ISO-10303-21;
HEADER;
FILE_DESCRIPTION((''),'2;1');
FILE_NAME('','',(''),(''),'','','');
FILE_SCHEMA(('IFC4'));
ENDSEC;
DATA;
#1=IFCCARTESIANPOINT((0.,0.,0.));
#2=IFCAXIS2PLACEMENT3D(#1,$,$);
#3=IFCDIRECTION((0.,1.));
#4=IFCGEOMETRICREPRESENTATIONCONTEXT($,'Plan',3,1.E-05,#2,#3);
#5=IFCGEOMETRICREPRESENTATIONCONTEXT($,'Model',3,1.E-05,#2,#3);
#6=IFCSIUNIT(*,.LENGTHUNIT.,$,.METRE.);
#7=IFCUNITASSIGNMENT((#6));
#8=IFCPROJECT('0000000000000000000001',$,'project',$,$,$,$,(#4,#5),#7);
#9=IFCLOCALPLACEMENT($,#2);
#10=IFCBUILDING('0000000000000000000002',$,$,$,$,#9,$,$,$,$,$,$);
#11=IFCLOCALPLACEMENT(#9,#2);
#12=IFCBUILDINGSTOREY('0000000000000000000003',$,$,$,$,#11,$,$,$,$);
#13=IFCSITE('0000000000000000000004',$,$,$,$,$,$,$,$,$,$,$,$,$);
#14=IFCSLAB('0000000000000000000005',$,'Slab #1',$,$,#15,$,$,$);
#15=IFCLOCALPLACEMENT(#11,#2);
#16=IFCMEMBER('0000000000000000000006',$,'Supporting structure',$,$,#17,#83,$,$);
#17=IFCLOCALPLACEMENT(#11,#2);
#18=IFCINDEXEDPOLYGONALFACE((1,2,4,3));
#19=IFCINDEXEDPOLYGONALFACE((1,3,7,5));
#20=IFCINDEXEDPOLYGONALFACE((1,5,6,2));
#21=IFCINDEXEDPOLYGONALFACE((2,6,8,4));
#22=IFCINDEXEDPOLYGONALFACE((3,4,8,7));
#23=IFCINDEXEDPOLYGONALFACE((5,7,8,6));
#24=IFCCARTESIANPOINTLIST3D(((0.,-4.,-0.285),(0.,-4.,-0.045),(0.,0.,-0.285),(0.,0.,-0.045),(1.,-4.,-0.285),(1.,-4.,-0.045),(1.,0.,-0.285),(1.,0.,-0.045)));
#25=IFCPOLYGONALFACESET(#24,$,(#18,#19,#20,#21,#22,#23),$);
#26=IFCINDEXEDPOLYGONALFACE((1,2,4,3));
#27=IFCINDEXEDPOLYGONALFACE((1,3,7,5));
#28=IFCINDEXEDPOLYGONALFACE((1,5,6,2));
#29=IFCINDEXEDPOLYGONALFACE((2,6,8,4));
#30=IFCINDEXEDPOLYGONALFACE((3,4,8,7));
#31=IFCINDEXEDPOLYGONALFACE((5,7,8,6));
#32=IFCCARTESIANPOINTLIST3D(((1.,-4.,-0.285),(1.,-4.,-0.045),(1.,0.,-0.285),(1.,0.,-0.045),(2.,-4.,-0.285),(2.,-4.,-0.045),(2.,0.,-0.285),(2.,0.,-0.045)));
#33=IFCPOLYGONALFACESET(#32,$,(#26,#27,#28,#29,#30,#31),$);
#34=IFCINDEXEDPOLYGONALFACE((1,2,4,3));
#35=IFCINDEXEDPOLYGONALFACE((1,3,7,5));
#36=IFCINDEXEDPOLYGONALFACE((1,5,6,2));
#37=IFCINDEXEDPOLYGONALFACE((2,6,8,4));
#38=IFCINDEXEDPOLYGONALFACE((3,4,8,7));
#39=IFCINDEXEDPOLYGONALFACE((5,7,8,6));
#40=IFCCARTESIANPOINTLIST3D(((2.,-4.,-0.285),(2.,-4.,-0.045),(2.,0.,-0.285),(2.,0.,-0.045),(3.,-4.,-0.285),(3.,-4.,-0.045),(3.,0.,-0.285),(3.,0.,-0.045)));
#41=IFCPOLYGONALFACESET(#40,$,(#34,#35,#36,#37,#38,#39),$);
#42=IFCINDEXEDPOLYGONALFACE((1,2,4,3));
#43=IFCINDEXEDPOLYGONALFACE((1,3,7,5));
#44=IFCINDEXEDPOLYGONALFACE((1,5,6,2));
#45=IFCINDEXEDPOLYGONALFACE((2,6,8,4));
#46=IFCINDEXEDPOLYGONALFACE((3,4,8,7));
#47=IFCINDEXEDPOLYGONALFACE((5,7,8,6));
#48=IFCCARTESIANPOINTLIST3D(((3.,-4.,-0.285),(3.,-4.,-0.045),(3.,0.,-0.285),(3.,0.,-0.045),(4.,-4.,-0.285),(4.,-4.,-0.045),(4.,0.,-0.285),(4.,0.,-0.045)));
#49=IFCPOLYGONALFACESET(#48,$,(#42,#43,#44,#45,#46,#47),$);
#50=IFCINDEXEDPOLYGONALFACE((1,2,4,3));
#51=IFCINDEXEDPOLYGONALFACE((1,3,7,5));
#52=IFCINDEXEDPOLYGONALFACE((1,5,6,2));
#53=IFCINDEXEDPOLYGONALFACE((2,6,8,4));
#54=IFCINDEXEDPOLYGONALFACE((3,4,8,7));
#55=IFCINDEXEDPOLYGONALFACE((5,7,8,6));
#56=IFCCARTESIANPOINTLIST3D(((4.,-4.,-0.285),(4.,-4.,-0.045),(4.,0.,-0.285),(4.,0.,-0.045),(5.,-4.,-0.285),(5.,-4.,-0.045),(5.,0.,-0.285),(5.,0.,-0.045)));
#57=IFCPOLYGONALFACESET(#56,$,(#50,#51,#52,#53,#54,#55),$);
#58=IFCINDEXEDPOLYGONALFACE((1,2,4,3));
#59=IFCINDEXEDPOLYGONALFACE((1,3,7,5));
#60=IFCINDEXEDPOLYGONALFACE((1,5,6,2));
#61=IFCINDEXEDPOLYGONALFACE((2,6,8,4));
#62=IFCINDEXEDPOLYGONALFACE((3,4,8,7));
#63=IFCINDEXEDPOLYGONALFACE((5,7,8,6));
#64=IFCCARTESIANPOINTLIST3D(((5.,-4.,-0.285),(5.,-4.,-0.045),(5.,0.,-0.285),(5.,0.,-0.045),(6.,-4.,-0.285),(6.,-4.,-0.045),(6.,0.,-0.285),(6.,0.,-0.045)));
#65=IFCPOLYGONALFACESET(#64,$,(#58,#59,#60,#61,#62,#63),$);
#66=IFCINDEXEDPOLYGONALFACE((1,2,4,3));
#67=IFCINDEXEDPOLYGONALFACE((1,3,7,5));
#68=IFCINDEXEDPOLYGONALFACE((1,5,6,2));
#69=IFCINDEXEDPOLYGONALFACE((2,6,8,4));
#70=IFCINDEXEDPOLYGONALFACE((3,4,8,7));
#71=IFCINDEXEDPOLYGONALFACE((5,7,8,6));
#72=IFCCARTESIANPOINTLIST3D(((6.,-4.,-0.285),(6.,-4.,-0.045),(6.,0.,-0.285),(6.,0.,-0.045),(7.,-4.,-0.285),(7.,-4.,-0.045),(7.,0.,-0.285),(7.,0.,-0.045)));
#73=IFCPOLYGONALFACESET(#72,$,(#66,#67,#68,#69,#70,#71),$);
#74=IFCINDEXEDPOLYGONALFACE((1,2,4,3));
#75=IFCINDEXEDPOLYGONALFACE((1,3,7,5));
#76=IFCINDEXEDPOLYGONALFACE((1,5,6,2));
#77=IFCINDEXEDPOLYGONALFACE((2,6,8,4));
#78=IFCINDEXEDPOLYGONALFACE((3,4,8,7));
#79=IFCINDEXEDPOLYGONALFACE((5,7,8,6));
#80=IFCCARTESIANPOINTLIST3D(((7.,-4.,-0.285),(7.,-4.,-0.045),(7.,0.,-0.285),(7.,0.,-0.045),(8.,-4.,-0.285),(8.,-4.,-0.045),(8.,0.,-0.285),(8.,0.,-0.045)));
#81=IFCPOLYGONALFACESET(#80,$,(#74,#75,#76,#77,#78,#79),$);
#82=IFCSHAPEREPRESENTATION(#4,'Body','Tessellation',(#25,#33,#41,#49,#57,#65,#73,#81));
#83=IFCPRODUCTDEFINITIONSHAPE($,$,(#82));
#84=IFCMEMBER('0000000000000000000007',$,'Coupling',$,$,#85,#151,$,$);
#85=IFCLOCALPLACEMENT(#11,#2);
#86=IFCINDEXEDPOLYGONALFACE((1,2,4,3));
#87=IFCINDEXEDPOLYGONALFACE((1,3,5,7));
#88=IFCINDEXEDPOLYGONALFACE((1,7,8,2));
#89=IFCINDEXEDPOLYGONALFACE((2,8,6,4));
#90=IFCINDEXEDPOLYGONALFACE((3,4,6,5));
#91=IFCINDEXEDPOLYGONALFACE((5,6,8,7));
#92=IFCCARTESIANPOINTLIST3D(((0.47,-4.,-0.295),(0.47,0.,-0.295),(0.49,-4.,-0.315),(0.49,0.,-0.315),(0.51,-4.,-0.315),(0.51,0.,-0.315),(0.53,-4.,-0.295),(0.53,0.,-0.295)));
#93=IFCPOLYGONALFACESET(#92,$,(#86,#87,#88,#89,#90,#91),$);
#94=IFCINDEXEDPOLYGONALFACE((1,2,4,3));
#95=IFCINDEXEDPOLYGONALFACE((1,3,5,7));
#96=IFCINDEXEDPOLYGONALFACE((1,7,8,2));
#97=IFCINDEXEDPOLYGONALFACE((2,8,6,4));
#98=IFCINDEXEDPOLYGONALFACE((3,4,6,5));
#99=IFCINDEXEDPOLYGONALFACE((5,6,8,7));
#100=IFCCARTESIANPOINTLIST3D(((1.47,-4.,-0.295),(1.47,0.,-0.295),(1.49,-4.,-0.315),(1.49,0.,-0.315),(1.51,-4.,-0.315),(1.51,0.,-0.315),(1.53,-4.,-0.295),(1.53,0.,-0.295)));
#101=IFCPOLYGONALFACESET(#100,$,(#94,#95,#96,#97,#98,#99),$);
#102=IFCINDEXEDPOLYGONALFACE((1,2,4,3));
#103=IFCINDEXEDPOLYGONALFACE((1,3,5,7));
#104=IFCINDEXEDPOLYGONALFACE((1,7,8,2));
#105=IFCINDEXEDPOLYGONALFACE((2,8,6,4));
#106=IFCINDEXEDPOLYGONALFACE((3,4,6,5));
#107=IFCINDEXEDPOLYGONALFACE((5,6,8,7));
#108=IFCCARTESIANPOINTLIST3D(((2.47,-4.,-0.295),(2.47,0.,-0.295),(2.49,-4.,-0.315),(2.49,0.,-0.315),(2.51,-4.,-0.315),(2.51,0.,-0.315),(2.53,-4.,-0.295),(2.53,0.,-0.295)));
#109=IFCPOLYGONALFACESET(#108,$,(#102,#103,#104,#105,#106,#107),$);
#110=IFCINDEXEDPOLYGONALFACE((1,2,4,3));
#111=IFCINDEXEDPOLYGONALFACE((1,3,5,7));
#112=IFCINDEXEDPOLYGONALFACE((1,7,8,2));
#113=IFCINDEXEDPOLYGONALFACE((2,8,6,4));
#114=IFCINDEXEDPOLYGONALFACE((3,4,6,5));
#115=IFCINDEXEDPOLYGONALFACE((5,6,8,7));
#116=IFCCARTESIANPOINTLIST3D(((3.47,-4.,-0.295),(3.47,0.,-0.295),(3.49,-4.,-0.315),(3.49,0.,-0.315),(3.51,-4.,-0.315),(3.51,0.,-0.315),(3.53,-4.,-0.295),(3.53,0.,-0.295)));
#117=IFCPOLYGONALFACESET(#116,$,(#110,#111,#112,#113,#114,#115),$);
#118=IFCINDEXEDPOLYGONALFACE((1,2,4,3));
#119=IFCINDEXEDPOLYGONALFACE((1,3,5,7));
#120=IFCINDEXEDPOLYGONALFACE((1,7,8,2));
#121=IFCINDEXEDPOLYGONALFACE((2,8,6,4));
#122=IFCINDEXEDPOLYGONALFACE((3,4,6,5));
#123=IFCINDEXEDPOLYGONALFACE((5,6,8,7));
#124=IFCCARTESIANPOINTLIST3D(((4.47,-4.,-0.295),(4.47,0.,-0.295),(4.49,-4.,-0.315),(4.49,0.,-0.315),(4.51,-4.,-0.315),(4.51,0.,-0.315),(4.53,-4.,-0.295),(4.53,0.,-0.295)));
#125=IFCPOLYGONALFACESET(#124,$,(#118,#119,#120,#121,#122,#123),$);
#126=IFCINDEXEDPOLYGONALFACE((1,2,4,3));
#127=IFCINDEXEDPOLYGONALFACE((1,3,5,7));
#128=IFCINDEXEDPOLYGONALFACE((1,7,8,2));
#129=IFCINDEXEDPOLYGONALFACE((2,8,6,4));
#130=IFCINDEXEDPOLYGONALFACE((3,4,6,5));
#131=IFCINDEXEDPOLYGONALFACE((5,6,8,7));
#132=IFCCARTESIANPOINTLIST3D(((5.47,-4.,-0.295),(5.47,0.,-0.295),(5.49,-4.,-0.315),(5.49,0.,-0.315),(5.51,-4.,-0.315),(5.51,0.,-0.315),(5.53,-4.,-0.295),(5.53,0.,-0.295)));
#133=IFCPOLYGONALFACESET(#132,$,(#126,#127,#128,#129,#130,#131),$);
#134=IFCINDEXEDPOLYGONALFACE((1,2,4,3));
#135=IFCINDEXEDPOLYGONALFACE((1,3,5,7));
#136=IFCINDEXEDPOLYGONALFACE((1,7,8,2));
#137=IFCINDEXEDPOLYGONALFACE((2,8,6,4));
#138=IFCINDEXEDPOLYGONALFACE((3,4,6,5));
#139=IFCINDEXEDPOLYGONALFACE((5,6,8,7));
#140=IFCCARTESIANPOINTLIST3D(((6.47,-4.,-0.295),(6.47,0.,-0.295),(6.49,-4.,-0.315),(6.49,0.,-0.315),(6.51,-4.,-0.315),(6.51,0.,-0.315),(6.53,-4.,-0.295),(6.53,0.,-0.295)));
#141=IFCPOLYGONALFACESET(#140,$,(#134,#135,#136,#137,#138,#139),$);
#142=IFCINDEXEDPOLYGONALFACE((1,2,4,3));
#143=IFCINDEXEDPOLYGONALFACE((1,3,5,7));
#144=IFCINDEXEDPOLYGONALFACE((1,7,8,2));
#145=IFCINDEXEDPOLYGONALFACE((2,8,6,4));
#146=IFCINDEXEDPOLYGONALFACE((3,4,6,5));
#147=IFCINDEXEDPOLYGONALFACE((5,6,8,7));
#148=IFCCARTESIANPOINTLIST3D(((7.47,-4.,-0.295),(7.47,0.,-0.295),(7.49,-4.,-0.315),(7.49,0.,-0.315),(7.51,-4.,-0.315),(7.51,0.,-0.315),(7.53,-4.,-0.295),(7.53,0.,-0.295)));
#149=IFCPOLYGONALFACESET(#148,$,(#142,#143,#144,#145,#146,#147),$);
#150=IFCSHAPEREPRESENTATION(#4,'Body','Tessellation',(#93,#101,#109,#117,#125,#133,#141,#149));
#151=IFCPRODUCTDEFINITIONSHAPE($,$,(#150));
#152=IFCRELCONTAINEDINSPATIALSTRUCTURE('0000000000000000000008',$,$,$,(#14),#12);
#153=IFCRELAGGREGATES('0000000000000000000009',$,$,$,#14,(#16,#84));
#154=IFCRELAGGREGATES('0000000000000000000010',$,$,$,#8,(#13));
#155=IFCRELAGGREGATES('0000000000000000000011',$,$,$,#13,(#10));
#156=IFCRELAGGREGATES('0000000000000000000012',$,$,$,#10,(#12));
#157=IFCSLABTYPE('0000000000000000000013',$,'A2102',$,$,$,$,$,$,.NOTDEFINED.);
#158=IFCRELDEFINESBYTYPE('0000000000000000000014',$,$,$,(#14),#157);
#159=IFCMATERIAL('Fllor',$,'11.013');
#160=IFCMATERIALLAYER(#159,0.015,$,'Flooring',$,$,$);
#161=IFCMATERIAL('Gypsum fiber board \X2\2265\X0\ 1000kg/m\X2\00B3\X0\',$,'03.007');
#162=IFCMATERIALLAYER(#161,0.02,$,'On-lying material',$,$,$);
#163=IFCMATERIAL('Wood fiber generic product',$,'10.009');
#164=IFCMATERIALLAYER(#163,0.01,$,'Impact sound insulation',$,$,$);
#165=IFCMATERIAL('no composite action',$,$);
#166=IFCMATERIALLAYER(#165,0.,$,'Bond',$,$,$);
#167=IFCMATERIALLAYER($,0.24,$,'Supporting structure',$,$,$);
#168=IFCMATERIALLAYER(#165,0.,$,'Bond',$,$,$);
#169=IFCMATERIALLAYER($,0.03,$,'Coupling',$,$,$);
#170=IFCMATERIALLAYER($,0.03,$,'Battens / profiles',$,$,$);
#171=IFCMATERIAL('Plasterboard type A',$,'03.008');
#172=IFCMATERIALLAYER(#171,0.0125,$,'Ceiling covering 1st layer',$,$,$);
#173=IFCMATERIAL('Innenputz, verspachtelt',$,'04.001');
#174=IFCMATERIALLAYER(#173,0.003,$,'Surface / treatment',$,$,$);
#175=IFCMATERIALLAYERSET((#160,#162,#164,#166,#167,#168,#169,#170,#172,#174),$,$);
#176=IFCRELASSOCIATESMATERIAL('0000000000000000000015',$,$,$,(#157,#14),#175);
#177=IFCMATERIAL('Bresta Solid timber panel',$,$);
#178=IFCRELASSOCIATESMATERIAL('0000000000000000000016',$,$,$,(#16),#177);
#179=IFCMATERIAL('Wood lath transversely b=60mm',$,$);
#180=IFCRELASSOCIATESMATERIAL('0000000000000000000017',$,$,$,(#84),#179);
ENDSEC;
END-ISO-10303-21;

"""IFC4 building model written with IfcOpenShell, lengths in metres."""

from ifc_helpers import new_model, si_unit, direction, frame, frame_2d, origin, place, context, project, spatial, polyline, rectangle, outline, extrude, material, layer, layer_set, type_object, element, aggregate, save


model = new_model("IFC4")

# Units and contexts
plan_context = context("Plan", 3, precision=1e-05, world=origin(), true_north=direction((0.0, 1.0)))
model_context = context("Model", 3, precision=1e-05, world=origin(), true_north=direction((0.0, 1.0)))
ifc_project = project(units=[si_unit("LENGTHUNIT", "METRE")], contexts=[plan_context, model_context])

# Site, building, storey
site = spatial("IfcSite", under=ifc_project)
building_placement = place(None, origin())
building = spatial("IfcBuilding", under=site, at=building_placement)
storey_placement = place(building_placement, origin())
storey = spatial("IfcBuildingStorey", under=building, at=storey_placement)

# Slab, members
ifc_material_1 = material(Name="Fllor", Category="11.013")
ifc_layer_1 = layer(ifc_material_1, 0.015, Name="Flooring")
ifc_material_2 = material(Name="Gypsum fiber board ≥ 1000kg/m³", Category="03.007")
ifc_layer_2 = layer(ifc_material_2, 0.02, Name="On-lying material")
ifc_material_3 = material(Name="Wood fiber generic product", Category="10.009")
ifc_layer_3 = layer(ifc_material_3, 0.01, Name="Impact sound insulation")
ifc_material_4 = material(Name="no composite action")
ifc_layer_4 = layer(ifc_material_4, 0.0, Name="Bond")
ifc_layer_5 = layer(None, 0.24, Name="Supporting structure")
ifc_layer_6 = layer(ifc_material_4, 0.0, Name="Bond")
ifc_layer_7 = layer(None, 0.03, Name="Coupling")
ifc_layer_8 = layer(None, 0.03, Name="Battens / profiles")
ifc_material_5 = material(Name="Plasterboard type A", Category="03.008")
ifc_layer_9 = layer(ifc_material_5, 0.0125, Name="Ceiling covering 1st layer")
ifc_material_6 = material(Name="Innenputz, verspachtelt", Category="04.001")
ifc_layer_10 = layer(ifc_material_6, 0.003, Name="Surface / treatment")
ifc_layer_set = layer_set([ifc_layer_1, ifc_layer_2, ifc_layer_3, ifc_layer_4, ifc_layer_5, ifc_layer_6, ifc_layer_7, ifc_layer_8, ifc_layer_9, ifc_layer_10])
slab_type = type_object("IfcSlabType", Name="A2102", PredefinedType="NOTDEFINED", material=ifc_layer_set)
slab_placement = place(None, frame((0.0, 0.0, 0.0), z_axis=(0.0, 0.0, -1.0), x_axis=(1.0, 0.0, 0.0)))
slab = element("IfcSlab", 1, at=slab_placement, inside=storey, type_object=slab_type, material=ifc_layer_set, Name="Slab #1")
ifc_material_7 = material(Name="Bresta Solid timber panel")
member_1_placement = place(slab_placement, origin())
member_1 = element("IfcMember", 2, at=member_1_placement, material=ifc_material_7, Name="Supporting structure", context=plan_context, shape_type="SweptSolid", body=[
    extrude(rectangle(XDim=1.0, YDim=0.24, at=frame_2d((0.5, 0.12), x_axis=(1.0, 0.0))), frame((0.0, 4.0, 0.045), z_axis=(0.0, -1.0, 0.0), x_axis=(1.0, 0.0, 0.0)), (0.0, 0.0, 1.0), 4.0),
    extrude(rectangle(XDim=1.0, YDim=0.24, at=frame_2d((0.5, 0.12), x_axis=(1.0, 0.0))), frame((1.0, 4.0, 0.045), z_axis=(0.0, -1.0, 0.0), x_axis=(1.0, 0.0, 0.0)), (0.0, 0.0, 1.0), 4.0),
    extrude(rectangle(XDim=1.0, YDim=0.24, at=frame_2d((0.5, 0.12), x_axis=(1.0, 0.0))), frame((2.0, 4.0, 0.045), z_axis=(0.0, -1.0, 0.0), x_axis=(1.0, 0.0, 0.0)), (0.0, 0.0, 1.0), 4.0),
    extrude(rectangle(XDim=1.0, YDim=0.24, at=frame_2d((0.5, 0.12), x_axis=(1.0, 0.0))), frame((3.0, 4.0, 0.045), z_axis=(0.0, -1.0, 0.0), x_axis=(1.0, 0.0, 0.0)), (0.0, 0.0, 1.0), 4.0),
    extrude(rectangle(XDim=1.0, YDim=0.24, at=frame_2d((0.5, 0.12), x_axis=(1.0, 0.0))), frame((4.0, 4.0, 0.045), z_axis=(0.0, -1.0, 0.0), x_axis=(1.0, 0.0, 0.0)), (0.0, 0.0, 1.0), 4.0),
    extrude(rectangle(XDim=1.0, YDim=0.24, at=frame_2d((0.5, 0.12), x_axis=(1.0, 0.0))), frame((5.0, 4.0, 0.045), z_axis=(0.0, -1.0, 0.0), x_axis=(1.0, 0.0, 0.0)), (0.0, 0.0, 1.0), 4.0),
    extrude(rectangle(XDim=1.0, YDim=0.24, at=frame_2d((0.5, 0.12), x_axis=(1.0, 0.0))), frame((6.0, 4.0, 0.045), z_axis=(0.0, -1.0, 0.0), x_axis=(1.0, 0.0, 0.0)), (0.0, 0.0, 1.0), 4.0),
    extrude(rectangle(XDim=1.0, YDim=0.24, at=frame_2d((0.5, 0.12), x_axis=(1.0, 0.0))), frame((7.0, 4.0, 0.045), z_axis=(0.0, -1.0, 0.0), x_axis=(1.0, 0.0, 0.0)), (0.0, 0.0, 1.0), 4.0),
])
ifc_material_8 = material(Name="Wood lath transversely b=60mm")
member_2_placement = place(slab_placement, origin())
member_2 = element("IfcMember", 3, at=member_2_placement, material=ifc_material_8, Name="Coupling", context=plan_context, shape_type="SweptSolid", body=[
    extrude(outline(polyline([(0.0, 0.0), (0.06, 0.0), (0.04, 0.02), (0.02, 0.02), (0.0, 0.0)])), frame((0.47, 4.0, 0.295), z_axis=(0.0, -1.0, 0.0), x_axis=(1.0, 0.0, 0.0)), (0.0, 0.0, 1.0), 4.0),
    extrude(outline(polyline([(0.0, 0.0), (0.06, 0.0), (0.04, 0.02), (0.02, 0.02), (0.0, 0.0)])), frame((1.47, 4.0, 0.295), z_axis=(0.0, -1.0, 0.0), x_axis=(1.0, 0.0, 0.0)), (0.0, 0.0, 1.0), 4.0),
    extrude(outline(polyline([(0.0, 0.0), (0.06, 0.0), (0.04, 0.02), (0.02, 0.02), (0.0, 0.0)])), frame((2.47, 4.0, 0.295), z_axis=(0.0, -1.0, 0.0), x_axis=(1.0, 0.0, 0.0)), (0.0, 0.0, 1.0), 4.0),
    extrude(outline(polyline([(0.0, 0.0), (0.06, 0.0), (0.04, 0.02), (0.02, 0.02), (0.0, 0.0)])), frame((3.47, 4.0, 0.295), z_axis=(0.0, -1.0, 0.0), x_axis=(1.0, 0.0, 0.0)), (0.0, 0.0, 1.0), 4.0),
    extrude(outline(polyline([(0.0, 0.0), (0.06, 0.0), (0.04, 0.02), (0.02, 0.02), (0.0, 0.0)])), frame((4.47, 4.0, 0.295), z_axis=(0.0, -1.0, 0.0), x_axis=(1.0, 0.0, 0.0)), (0.0, 0.0, 1.0), 4.0),
    extrude(outline(polyline([(0.0, 0.0), (0.06, 0.0), (0.04, 0.02), (0.02, 0.02), (0.0, 0.0)])), frame((5.47, 4.0, 0.295), z_axis=(0.0, -1.0, 0.0), x_axis=(1.0, 0.0, 0.0)), (0.0, 0.0, 1.0), 4.0),
    extrude(outline(polyline([(0.0, 0.0), (0.06, 0.0), (0.04, 0.02), (0.02, 0.02), (0.0, 0.0)])), frame((6.47, 4.0, 0.295), z_axis=(0.0, -1.0, 0.0), x_axis=(1.0, 0.0, 0.0)), (0.0, 0.0, 1.0), 4.0),
    extrude(outline(polyline([(0.0, 0.0), (0.06, 0.0), (0.04, 0.02), (0.02, 0.02), (0.0, 0.0)])), frame((7.47, 4.0, 0.295), z_axis=(0.0, -1.0, 0.0), x_axis=(1.0, 0.0, 0.0)), (0.0, 0.0, 1.0), 4.0),
])
aggregate(slab, [member_1, member_2])

save(model, "model.ifc")
